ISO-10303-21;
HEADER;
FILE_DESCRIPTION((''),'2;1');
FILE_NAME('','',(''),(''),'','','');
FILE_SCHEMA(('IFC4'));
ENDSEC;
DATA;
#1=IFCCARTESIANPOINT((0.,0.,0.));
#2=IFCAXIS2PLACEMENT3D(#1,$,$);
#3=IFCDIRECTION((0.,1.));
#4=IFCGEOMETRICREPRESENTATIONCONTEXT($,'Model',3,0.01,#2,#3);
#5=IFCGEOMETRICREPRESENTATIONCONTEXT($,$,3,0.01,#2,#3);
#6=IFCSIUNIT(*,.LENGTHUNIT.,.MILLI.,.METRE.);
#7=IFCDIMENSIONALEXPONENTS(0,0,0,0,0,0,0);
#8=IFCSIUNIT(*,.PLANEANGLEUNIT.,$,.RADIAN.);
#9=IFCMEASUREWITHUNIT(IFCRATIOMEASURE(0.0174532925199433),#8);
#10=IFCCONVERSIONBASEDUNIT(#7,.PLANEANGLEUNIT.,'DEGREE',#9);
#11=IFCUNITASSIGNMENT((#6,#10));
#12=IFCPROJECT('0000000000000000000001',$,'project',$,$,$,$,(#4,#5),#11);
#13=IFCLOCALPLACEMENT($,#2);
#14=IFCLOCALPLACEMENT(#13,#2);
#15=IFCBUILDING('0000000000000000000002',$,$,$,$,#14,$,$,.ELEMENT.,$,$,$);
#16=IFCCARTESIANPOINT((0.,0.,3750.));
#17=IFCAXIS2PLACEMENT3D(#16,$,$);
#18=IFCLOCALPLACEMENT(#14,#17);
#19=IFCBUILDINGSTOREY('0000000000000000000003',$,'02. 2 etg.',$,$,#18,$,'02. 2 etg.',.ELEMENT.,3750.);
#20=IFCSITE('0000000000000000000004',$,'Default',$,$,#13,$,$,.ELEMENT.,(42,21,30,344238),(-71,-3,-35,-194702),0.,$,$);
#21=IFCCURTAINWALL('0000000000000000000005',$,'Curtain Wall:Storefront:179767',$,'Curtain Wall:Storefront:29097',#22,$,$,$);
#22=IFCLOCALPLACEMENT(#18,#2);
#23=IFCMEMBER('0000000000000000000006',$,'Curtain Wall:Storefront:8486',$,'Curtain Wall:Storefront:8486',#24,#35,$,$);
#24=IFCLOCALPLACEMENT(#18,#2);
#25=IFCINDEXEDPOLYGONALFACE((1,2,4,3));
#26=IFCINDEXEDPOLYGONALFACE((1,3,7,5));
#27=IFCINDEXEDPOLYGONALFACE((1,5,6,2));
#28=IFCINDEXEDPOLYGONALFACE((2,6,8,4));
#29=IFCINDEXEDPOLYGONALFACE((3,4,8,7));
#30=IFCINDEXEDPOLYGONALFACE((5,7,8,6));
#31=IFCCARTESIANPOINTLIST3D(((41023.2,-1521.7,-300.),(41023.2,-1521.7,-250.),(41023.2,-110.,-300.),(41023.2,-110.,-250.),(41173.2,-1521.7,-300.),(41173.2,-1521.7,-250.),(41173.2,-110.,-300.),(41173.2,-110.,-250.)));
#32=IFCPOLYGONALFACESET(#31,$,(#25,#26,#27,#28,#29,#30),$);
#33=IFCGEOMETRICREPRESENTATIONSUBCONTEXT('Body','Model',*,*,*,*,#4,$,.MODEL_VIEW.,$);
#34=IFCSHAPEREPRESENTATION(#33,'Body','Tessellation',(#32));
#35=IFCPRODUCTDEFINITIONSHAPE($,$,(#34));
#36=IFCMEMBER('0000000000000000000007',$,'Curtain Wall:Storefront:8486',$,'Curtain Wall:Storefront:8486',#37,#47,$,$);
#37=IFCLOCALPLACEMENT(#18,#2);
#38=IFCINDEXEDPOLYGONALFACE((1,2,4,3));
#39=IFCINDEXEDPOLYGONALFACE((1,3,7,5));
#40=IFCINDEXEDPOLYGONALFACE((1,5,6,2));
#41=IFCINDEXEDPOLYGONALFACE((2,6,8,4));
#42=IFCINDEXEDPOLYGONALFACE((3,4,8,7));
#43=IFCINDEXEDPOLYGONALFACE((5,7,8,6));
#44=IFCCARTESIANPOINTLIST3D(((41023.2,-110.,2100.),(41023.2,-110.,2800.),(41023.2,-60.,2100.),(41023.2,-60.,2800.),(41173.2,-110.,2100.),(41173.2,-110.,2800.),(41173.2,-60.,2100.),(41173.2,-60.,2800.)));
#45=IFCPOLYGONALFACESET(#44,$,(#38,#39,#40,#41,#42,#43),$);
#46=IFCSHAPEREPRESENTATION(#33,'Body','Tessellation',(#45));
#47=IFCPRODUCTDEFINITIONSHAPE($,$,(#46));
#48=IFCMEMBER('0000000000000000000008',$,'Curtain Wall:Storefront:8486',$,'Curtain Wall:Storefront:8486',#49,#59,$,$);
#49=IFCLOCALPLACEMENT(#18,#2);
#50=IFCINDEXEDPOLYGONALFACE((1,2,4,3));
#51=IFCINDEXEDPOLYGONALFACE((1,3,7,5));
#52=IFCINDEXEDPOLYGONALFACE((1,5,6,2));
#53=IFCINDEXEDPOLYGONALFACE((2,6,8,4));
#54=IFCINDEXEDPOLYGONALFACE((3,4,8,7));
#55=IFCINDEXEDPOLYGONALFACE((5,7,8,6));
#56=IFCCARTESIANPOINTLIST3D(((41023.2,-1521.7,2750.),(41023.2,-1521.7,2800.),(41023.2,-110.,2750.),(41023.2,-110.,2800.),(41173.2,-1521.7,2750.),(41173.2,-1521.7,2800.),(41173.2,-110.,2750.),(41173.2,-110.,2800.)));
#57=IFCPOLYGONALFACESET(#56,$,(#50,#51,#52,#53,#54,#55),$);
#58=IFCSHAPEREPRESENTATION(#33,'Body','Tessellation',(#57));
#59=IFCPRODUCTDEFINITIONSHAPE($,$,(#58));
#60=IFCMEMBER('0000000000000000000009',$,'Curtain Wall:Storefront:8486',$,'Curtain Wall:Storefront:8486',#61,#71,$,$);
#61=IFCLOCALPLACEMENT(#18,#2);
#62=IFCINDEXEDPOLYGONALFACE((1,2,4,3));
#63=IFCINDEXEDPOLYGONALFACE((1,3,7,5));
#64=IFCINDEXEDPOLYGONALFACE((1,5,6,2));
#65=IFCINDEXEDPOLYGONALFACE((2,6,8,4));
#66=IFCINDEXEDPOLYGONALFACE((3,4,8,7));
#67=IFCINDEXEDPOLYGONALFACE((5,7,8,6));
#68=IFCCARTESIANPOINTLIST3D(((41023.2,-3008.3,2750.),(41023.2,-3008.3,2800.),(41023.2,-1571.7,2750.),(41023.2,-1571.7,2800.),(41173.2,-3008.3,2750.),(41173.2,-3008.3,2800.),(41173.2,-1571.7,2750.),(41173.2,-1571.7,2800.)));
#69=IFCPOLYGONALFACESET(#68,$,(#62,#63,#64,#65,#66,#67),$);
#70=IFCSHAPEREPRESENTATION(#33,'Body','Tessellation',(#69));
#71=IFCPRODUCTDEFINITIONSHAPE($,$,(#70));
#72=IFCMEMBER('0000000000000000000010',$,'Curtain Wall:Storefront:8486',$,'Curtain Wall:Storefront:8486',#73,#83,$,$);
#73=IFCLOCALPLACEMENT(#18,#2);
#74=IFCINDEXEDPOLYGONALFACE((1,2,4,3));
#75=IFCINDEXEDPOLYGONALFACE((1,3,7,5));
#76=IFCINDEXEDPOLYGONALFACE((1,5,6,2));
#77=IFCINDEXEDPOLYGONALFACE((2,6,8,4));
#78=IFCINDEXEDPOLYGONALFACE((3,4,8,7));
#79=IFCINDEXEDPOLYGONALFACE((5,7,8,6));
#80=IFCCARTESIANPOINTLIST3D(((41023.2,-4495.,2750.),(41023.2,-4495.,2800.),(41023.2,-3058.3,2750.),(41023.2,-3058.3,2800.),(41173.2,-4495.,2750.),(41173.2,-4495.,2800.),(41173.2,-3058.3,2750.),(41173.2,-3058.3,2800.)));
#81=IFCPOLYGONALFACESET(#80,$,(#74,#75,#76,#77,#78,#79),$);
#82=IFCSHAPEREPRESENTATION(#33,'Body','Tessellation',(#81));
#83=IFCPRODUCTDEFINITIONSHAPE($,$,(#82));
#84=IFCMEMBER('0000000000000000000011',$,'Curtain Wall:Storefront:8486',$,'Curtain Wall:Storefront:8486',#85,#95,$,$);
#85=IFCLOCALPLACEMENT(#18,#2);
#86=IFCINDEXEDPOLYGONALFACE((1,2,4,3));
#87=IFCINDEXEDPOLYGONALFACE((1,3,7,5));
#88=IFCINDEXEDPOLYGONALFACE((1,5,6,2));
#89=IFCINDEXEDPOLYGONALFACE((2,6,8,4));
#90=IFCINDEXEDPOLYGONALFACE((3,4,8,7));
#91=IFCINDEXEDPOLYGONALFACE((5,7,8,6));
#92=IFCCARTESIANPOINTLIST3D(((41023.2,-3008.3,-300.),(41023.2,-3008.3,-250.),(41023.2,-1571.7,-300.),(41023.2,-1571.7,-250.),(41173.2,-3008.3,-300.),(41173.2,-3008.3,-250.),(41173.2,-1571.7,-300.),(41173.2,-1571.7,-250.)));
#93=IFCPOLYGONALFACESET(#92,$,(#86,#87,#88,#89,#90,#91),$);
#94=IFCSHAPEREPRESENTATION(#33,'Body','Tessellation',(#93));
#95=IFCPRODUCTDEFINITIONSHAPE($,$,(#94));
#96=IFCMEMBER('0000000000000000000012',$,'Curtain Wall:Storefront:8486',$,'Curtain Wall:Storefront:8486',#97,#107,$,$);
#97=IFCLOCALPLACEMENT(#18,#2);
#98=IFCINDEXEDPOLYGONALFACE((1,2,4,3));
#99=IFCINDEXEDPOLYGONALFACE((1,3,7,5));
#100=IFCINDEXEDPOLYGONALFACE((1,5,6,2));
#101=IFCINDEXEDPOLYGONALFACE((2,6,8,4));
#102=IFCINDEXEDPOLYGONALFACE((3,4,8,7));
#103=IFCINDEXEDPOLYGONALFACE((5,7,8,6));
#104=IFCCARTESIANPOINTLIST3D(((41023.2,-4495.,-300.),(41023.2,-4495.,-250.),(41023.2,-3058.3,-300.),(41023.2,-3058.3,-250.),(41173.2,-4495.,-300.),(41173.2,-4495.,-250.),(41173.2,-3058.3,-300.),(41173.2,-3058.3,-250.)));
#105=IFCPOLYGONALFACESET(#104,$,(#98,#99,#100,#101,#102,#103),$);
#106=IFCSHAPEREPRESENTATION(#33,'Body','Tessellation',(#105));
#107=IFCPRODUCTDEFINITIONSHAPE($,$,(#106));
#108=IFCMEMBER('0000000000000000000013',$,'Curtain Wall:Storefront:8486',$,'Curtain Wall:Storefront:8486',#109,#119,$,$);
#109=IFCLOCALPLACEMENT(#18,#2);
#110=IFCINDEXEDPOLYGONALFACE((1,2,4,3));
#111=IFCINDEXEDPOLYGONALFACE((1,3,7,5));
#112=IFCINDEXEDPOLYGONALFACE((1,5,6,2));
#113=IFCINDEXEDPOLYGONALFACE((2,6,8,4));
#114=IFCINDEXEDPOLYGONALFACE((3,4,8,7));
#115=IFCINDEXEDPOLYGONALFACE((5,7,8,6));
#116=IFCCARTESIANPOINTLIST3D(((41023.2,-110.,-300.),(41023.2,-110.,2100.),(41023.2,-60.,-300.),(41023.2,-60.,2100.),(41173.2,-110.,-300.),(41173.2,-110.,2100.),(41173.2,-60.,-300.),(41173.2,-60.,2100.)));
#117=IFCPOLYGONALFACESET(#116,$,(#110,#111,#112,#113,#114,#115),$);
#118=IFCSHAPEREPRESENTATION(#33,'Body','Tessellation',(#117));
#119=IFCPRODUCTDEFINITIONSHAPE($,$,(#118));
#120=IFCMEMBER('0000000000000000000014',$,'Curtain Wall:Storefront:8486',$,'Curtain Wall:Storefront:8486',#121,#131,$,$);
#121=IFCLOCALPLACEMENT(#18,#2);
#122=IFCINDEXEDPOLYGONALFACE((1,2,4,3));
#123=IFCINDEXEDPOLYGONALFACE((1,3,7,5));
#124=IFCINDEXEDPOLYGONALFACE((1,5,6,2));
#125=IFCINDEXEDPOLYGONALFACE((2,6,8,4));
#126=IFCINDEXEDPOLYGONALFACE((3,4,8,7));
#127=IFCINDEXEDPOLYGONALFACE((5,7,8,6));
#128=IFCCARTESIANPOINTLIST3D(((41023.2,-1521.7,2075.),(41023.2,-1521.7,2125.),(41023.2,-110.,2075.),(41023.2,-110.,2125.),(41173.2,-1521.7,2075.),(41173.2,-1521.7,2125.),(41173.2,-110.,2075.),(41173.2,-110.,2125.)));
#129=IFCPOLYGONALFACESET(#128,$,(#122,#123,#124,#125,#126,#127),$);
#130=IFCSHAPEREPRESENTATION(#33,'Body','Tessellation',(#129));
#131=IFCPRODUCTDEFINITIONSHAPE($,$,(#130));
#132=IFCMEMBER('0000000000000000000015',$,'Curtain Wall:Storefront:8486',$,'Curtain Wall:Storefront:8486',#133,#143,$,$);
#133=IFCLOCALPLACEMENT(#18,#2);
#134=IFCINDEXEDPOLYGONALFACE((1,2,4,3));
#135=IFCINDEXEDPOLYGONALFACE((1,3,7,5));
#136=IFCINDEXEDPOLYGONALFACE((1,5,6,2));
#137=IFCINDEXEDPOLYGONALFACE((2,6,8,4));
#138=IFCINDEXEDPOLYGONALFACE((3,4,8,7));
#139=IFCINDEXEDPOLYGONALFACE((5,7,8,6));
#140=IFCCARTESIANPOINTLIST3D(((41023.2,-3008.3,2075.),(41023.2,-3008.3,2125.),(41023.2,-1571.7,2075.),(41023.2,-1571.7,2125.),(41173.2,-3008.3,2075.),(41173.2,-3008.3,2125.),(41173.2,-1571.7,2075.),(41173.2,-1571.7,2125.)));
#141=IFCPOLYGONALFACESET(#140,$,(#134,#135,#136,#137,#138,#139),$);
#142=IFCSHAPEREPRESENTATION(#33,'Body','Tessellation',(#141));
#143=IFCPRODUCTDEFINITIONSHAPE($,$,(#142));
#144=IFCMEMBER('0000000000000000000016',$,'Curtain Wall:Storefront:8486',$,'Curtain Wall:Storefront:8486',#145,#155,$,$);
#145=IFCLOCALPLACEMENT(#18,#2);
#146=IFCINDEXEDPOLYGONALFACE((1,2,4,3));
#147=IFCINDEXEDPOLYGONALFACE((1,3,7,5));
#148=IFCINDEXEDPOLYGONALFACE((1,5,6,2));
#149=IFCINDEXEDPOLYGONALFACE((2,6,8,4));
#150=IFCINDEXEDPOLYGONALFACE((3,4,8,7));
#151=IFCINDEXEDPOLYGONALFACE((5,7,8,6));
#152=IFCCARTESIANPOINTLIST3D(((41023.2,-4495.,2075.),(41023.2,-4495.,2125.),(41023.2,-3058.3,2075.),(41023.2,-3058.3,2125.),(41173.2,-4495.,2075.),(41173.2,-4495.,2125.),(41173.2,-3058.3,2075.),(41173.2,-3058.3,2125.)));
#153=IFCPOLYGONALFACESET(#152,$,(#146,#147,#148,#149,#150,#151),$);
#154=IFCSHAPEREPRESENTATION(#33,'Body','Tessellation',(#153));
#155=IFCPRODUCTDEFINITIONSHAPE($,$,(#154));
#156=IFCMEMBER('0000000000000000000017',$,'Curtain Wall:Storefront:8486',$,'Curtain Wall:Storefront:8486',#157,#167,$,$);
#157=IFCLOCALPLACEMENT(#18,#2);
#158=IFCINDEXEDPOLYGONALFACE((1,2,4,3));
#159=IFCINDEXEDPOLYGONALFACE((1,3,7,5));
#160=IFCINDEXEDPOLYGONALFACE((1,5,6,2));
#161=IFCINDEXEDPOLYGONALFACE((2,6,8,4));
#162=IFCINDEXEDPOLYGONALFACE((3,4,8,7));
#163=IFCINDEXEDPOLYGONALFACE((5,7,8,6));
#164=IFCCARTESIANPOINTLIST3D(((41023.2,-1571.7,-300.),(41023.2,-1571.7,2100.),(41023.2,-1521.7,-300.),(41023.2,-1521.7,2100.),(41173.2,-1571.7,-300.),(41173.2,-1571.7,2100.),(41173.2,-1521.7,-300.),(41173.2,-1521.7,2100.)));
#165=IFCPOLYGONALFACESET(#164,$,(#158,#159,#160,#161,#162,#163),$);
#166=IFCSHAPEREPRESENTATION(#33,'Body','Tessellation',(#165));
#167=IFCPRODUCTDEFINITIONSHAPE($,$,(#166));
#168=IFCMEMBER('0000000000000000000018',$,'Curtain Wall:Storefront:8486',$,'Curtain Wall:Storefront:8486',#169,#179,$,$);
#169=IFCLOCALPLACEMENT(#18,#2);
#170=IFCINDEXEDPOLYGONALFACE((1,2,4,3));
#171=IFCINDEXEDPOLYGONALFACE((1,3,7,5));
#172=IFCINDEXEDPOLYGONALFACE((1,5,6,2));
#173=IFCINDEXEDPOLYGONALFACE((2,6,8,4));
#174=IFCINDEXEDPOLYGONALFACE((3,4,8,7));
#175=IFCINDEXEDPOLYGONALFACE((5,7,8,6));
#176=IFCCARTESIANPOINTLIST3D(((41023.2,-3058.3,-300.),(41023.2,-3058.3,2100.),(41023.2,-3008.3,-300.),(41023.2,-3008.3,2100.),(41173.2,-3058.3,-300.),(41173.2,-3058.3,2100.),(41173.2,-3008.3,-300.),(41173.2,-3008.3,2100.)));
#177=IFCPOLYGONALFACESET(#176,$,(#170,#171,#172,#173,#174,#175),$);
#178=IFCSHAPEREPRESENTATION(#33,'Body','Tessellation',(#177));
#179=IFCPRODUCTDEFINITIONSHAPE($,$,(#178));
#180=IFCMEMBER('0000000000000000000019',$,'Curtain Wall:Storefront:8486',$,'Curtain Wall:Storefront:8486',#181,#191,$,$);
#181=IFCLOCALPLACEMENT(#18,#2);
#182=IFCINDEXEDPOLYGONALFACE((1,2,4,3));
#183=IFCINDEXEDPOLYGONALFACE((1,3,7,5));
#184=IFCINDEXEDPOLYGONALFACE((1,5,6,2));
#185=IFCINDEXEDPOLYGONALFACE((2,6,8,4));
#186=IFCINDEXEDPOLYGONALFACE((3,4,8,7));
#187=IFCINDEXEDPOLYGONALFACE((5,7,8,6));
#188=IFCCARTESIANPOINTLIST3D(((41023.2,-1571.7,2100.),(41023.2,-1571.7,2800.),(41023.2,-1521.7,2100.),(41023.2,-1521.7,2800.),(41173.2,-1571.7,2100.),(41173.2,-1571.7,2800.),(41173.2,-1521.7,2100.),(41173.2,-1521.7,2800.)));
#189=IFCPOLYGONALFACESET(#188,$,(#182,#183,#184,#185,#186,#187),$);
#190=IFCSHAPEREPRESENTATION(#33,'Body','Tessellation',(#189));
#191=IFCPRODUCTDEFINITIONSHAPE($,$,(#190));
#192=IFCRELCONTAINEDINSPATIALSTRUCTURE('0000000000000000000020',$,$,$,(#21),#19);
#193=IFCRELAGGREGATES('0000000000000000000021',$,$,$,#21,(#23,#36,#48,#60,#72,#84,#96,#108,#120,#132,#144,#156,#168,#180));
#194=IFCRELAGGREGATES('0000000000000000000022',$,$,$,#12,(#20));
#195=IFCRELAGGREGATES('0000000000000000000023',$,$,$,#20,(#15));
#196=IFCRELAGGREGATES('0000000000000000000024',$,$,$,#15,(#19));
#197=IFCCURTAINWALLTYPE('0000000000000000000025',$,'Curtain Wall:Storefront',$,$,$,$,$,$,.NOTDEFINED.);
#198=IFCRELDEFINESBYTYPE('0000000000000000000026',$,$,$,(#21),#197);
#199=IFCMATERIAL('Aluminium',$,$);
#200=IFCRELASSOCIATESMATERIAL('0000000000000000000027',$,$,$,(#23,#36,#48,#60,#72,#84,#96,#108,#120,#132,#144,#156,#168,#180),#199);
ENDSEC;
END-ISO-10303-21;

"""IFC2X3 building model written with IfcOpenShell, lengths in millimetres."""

from ifc_helpers import new_model, entity, si_unit, converted_unit, direction, frame, frame_2d, origin, origin_2d_with_axis, place, context, subcontext, project, spatial, rectangle, extrude, material, type_object, element, aggregate, save


model = new_model("IFC2X3")

# Units and contexts
model_context = context("Model", 3, precision=0.01, world=origin(), true_north=direction((0.0, 1.0)))
context_of_model = context(None, 3, precision=0.01, world=origin(), true_north=direction((0.0, 1.0)))
body_context = subcontext(model_context, "Body", "Model", "MODEL_VIEW")
ifc_project = project(units=[si_unit("LENGTHUNIT", "METRE", prefix="MILLI"), converted_unit("PLANEANGLEUNIT", "DEGREE", entity("IfcRatioMeasure", 0.0174532925199433), si_unit("PLANEANGLEUNIT", "RADIAN"), dimensions=[0, 0, 0, 0, 0, 0, 0])], contexts=[model_context, context_of_model])

# Site, building, storey
site_placement = place(None, origin())
site = spatial("IfcSite", under=ifc_project, at=site_placement, Name="Default", CompositionType="ELEMENT", RefLatitude=(42, 21, 30, 344238), RefLongitude=(-71, -3, -35, -194702), RefElevation=0.0)
building_placement = place(site_placement, origin())
building = spatial("IfcBuilding", under=site, at=building_placement, CompositionType="ELEMENT")
storey_placement = place(building_placement, frame((0.0, 0.0, 3750.0)))
storey = spatial("IfcBuildingStorey", under=building, at=storey_placement, Name="02. 2 etg.", LongName="02. 2 etg.", CompositionType="ELEMENT", Elevation=3750.0)

# Curtain wall, members
curtain_wall_type = type_object("IfcCurtainWallType", Name="Curtain Wall:Storefront", PredefinedType="NOTDEFINED")
curtain_wall_placement = place(storey_placement, frame((0.0, 0.0, -3750.0)))
curtain_wall = element("IfcCurtainWall", 1, at=curtain_wall_placement, inside=storey, type_object=curtain_wall_type, Name="Curtain Wall:Storefront:179767", ObjectType="Curtain Wall:Storefront:29097")
ifc_material_1 = material(Name="Aluminium")
member_1_placement = place(curtain_wall_placement, frame((41023.2, -1521.7, 3450.0)))
member_1 = element("IfcMember", 2, at=member_1_placement, material=ifc_material_1, Name="Curtain Wall:Storefront:8486", ObjectType="Curtain Wall:Storefront:8486", context=body_context, shape_type="SweptSolid", body=[
    extrude(rectangle(XDim=1411.7, YDim=150.0, at=origin_2d_with_axis()), frame((75.0, 705.8, 0.0), z_axis=(0.0, 0.0, 1.0), x_axis=(0.0, -1.0, 0.0)), (0.0, 0.0, 1.0), 50.0),
])
member_2_placement = place(curtain_wall_placement, frame((41023.2, -110.0, 5850.0)))
member_2 = element("IfcMember", 3, at=member_2_placement, material=ifc_material_1, Name="Curtain Wall:Storefront:8486", ObjectType="Curtain Wall:Storefront:8486", context=body_context, shape_type="SweptSolid", body=[
    extrude(rectangle(XDim=50.0, YDim=150.0, at=origin_2d_with_axis()), frame((75.0, 25.0, 0.0), z_axis=(0.0, 0.0, 1.0), x_axis=(0.0, -1.0, 0.0)), (0.0, 0.0, 1.0), 700.0),
])
member_3_placement = place(curtain_wall_placement, frame((41023.2, -1521.7, 6500.0)))
member_3 = element("IfcMember", 4, at=member_3_placement, material=ifc_material_1, Name="Curtain Wall:Storefront:8486", ObjectType="Curtain Wall:Storefront:8486", context=body_context, shape_type="SweptSolid", body=[
    extrude(rectangle(XDim=1411.7, YDim=150.0, at=origin_2d_with_axis()), frame((75.0, 705.8, 0.0), z_axis=(0.0, 0.0, 1.0), x_axis=(0.0, 1.0, 0.0)), (0.0, 0.0, 1.0), 50.0),
])
member_4_placement = place(curtain_wall_placement, frame((41023.2, -3008.3, 6500.0)))
member_4 = element("IfcMember", 5, at=member_4_placement, material=ifc_material_1, Name="Curtain Wall:Storefront:8486", ObjectType="Curtain Wall:Storefront:8486", context=body_context, shape_type="SweptSolid", body=[
    extrude(rectangle(XDim=1436.7, YDim=150.0, at=frame_2d((0.0, 0.0), x_axis=(1.0, 0.0))), frame((75.0, 718.3, 0.0), z_axis=(0.0, 0.0, 1.0), x_axis=(0.0, 1.0, 0.0)), (0.0, 0.0, 1.0), 50.0),
])
member_5_placement = place(curtain_wall_placement, frame((41023.2, -4495.0, 6500.0)))
member_5 = element("IfcMember", 6, at=member_5_placement, material=ifc_material_1, Name="Curtain Wall:Storefront:8486", ObjectType="Curtain Wall:Storefront:8486", context=body_context, shape_type="SweptSolid", body=[
    extrude(rectangle(XDim=1436.7, YDim=150.0, at=origin_2d_with_axis()), frame((75.0, 718.3, 0.0), z_axis=(0.0, 0.0, 1.0), x_axis=(0.0, 1.0, 0.0)), (0.0, 0.0, 1.0), 50.0),
])
member_6_placement = place(curtain_wall_placement, frame((41023.2, -3008.3, 3450.0)))
member_6 = element("IfcMember", 7, at=member_6_placement, material=ifc_material_1, Name="Curtain Wall:Storefront:8486", ObjectType="Curtain Wall:Storefront:8486", context=body_context, shape_type="SweptSolid", body=[
    extrude(rectangle(XDim=1436.7, YDim=150.0, at=frame_2d((0.0, 0.0), x_axis=(1.0, 0.0))), frame((75.0, 718.3, 0.0), z_axis=(0.0, 0.0, 1.0), x_axis=(0.0, -1.0, 0.0)), (0.0, 0.0, 1.0), 50.0),
])
member_7_placement = place(curtain_wall_placement, frame((41023.2, -4495.0, 3450.0)))
member_7 = element("IfcMember", 8, at=member_7_placement, material=ifc_material_1, Name="Curtain Wall:Storefront:8486", ObjectType="Curtain Wall:Storefront:8486", context=body_context, shape_type="SweptSolid", body=[
    extrude(rectangle(XDim=1436.7, YDim=150.0, at=origin_2d_with_axis()), frame((75.0, 718.3, 0.0), z_axis=(0.0, 0.0, 1.0), x_axis=(0.0, -1.0, 0.0)), (0.0, 0.0, 1.0), 50.0),
])
member_8_placement = place(curtain_wall_placement, frame((41023.2, -110.0, 3450.0)))
member_8 = element("IfcMember", 9, at=member_8_placement, material=ifc_material_1, Name="Curtain Wall:Storefront:8486", ObjectType="Curtain Wall:Storefront:8486", context=body_context, shape_type="SweptSolid", body=[
    extrude(rectangle(XDim=50.0, YDim=150.0, at=frame_2d((0.0, 0.0), x_axis=(1.0, 0.0))), frame((75.0, 25.0, 0.0), z_axis=(0.0, 0.0, 1.0), x_axis=(0.0, -1.0, 0.0)), (0.0, 0.0, 1.0), 2400.0),
])
member_9_placement = place(curtain_wall_placement, frame((41023.2, -1521.7, 5825.0)))
member_9 = element("IfcMember", 10, at=member_9_placement, material=ifc_material_1, Name="Curtain Wall:Storefront:8486", ObjectType="Curtain Wall:Storefront:8486", context=body_context, shape_type="SweptSolid", body=[
    extrude(rectangle(XDim=1411.7, YDim=150.0, at=origin_2d_with_axis()), frame((75.0, 705.8, 0.0), z_axis=(0.0, 0.0, 1.0), x_axis=(0.0, 1.0, 0.0)), (0.0, 0.0, 1.0), 50.0),
])
member_10_placement = place(curtain_wall_placement, frame((41023.2, -3008.3, 5825.0)))
member_10 = element("IfcMember", 11, at=member_10_placement, material=ifc_material_1, Name="Curtain Wall:Storefront:8486", ObjectType="Curtain Wall:Storefront:8486", context=body_context, shape_type="SweptSolid", body=[
    extrude(rectangle(XDim=1436.7, YDim=150.0, at=frame_2d((0.0, 0.0), x_axis=(1.0, 0.0))), frame((75.0, 718.3, 0.0), z_axis=(0.0, 0.0, 1.0), x_axis=(0.0, 1.0, 0.0)), (0.0, 0.0, 1.0), 50.0),
])
member_11_placement = place(curtain_wall_placement, frame((41023.2, -4495.0, 5825.0)))
member_11 = element("IfcMember", 12, at=member_11_placement, material=ifc_material_1, Name="Curtain Wall:Storefront:8486", ObjectType="Curtain Wall:Storefront:8486", context=body_context, shape_type="SweptSolid", body=[
    extrude(rectangle(XDim=1436.7, YDim=150.0, at=origin_2d_with_axis()), frame((75.0, 718.3, 0.0), z_axis=(0.0, 0.0, 1.0), x_axis=(0.0, 1.0, 0.0)), (0.0, 0.0, 1.0), 50.0),
])
member_12_placement = place(curtain_wall_placement, frame((41023.2, -1571.7, 3450.0)))
member_12 = element("IfcMember", 13, at=member_12_placement, material=ifc_material_1, Name="Curtain Wall:Storefront:8486", ObjectType="Curtain Wall:Storefront:8486", context=body_context, shape_type="SweptSolid", body=[
    extrude(rectangle(XDim=150.0, YDim=50.0, at=frame_2d((0.0, 0.0), x_axis=(1.0, 0.0))), frame((75.0, 25.0, 0.0)), (0.0, 0.0, 1.0), 2400.0),
])
member_13_placement = place(curtain_wall_placement, frame((41023.2, -3058.3, 3450.0)))
member_13 = element("IfcMember", 14, at=member_13_placement, material=ifc_material_1, Name="Curtain Wall:Storefront:8486", ObjectType="Curtain Wall:Storefront:8486", context=body_context, shape_type="SweptSolid", body=[
    extrude(rectangle(XDim=150.0, YDim=50.0, at=frame_2d((0.0, 0.0), x_axis=(1.0, 0.0))), frame((75.0, 25.0, 0.0)), (0.0, 0.0, 1.0), 2400.0),
])
member_14_placement = place(curtain_wall_placement, frame((41023.2, -1571.7, 5850.0)))
member_14 = element("IfcMember", 15, at=member_14_placement, material=ifc_material_1, Name="Curtain Wall:Storefront:8486", ObjectType="Curtain Wall:Storefront:8486", context=body_context, shape_type="SweptSolid", body=[
    extrude(rectangle(XDim=150.0, YDim=50.0, at=origin_2d_with_axis()), frame((75.0, 25.0, 0.0)), (0.0, 0.0, 1.0), 700.0),
])
aggregate(curtain_wall, [member_1, member_2, member_3, member_4, member_5, member_6, member_7, member_8, member_9, member_10, member_11, member_12, member_13, member_14])

save(model, "model.ifc")
